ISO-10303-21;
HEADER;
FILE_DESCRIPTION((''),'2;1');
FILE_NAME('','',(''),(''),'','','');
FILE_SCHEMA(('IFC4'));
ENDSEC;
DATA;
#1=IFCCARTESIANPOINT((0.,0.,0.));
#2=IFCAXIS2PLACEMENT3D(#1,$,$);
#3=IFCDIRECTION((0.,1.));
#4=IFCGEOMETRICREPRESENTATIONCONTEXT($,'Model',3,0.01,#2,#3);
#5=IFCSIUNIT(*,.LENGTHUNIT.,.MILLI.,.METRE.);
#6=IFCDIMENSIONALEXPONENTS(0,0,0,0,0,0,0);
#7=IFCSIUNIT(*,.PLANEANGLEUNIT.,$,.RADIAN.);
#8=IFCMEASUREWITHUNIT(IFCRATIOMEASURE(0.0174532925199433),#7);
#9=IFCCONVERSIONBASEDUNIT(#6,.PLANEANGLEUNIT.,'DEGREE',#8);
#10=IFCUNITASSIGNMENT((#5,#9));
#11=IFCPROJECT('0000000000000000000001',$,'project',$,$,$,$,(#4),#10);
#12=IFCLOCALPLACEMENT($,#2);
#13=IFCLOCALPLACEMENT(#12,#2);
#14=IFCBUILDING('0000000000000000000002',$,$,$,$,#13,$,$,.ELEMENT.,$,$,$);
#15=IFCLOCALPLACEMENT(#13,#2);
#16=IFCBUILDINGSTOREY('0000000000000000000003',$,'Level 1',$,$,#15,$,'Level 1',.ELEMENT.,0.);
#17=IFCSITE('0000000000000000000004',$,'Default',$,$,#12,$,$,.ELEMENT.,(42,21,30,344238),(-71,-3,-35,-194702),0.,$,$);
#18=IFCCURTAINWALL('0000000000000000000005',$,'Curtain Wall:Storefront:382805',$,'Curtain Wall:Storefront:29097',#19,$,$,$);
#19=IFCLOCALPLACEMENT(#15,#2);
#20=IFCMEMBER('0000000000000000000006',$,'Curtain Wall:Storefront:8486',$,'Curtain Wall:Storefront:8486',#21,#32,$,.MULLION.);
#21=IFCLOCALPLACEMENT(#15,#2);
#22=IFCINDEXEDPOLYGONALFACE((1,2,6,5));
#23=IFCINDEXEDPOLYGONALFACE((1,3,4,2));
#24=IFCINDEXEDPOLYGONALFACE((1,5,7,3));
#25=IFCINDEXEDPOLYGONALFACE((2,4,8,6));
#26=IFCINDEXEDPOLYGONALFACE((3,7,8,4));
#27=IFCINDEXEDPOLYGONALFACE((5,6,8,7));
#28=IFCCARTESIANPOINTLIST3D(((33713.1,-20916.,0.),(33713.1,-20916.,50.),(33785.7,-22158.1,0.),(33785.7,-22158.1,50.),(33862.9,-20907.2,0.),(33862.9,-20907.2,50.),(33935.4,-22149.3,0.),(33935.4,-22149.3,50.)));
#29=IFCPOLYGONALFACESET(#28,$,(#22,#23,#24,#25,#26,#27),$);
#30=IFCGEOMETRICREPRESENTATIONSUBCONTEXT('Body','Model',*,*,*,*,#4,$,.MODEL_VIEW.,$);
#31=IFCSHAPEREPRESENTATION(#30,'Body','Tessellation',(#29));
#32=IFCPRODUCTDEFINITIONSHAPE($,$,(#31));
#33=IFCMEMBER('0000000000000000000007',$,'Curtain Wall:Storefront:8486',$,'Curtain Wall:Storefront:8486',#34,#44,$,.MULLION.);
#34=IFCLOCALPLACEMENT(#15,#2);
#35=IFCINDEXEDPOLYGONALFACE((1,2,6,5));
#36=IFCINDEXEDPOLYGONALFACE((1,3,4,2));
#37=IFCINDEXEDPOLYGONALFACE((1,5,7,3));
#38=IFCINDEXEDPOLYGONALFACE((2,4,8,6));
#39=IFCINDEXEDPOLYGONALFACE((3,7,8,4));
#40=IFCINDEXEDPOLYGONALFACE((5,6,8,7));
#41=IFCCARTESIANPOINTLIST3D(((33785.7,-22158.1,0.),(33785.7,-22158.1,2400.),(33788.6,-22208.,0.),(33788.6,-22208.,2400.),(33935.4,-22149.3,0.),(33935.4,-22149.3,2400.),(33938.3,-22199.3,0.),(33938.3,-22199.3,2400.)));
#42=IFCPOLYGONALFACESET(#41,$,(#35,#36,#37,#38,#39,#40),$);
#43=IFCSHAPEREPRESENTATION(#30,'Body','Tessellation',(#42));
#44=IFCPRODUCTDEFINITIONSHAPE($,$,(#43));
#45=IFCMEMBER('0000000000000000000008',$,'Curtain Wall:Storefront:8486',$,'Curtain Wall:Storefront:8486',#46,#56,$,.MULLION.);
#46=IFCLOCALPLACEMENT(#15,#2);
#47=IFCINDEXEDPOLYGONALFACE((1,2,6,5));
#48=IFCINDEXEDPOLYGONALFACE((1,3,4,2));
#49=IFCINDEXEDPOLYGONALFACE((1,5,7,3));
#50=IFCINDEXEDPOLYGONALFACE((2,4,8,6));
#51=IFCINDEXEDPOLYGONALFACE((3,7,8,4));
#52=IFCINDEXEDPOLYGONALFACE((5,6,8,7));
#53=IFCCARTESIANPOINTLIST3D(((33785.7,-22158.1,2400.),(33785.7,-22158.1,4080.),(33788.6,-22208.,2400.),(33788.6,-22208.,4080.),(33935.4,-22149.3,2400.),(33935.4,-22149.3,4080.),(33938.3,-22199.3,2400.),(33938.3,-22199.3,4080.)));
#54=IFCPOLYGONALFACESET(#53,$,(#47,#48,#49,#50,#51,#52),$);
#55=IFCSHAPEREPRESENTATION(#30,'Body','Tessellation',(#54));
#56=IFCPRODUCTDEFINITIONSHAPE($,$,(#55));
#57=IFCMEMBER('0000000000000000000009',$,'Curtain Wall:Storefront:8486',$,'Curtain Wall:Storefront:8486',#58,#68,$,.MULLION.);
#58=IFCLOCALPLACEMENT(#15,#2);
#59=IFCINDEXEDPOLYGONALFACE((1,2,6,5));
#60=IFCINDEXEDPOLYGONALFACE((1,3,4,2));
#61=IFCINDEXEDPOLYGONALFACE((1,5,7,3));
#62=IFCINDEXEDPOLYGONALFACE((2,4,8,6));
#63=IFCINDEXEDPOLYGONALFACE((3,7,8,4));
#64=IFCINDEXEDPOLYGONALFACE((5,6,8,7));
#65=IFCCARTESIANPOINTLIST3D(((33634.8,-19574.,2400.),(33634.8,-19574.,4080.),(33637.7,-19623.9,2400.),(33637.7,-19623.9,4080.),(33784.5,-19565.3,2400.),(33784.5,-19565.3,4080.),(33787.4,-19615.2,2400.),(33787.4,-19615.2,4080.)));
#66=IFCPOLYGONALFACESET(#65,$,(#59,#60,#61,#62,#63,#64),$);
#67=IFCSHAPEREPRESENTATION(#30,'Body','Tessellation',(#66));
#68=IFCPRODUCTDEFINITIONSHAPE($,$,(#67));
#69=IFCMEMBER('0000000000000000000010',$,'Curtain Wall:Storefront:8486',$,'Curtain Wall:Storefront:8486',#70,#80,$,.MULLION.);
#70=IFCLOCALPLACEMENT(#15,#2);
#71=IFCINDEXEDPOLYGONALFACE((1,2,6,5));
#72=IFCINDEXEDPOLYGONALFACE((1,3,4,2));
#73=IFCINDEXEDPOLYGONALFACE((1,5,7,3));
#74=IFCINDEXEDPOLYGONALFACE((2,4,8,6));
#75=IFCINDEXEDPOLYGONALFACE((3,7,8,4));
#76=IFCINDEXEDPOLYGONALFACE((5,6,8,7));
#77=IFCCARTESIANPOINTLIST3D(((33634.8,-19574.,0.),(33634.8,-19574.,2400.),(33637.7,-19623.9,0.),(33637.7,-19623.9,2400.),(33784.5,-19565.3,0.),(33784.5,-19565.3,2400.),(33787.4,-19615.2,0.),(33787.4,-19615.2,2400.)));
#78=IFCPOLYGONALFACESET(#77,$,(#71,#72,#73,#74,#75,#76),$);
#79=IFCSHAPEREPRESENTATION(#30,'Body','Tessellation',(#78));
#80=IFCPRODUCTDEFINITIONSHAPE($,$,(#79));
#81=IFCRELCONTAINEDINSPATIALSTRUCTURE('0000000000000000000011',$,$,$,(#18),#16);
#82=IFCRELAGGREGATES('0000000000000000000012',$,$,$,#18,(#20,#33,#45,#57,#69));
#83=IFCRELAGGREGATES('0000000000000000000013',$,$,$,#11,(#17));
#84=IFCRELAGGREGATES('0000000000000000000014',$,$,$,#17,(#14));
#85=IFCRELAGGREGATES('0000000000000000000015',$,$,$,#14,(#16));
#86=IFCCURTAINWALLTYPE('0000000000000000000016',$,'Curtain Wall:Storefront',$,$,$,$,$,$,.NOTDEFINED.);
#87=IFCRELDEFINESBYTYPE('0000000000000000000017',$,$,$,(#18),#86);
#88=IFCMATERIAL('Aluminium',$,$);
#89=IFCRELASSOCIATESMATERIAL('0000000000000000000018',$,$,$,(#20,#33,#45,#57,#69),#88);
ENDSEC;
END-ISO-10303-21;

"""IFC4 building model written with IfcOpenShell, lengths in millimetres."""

from ifc_helpers import new_model, entity, si_unit, converted_unit, direction, frame, origin, origin_2d_with_axis, place, context, subcontext, project, spatial, rectangle, extrude, material, type_object, element, aggregate, save


model = new_model("IFC4")

# Units and contexts
model_context = context("Model", 3, precision=0.01, world=origin(), true_north=direction((0.0, 1.0)))
body_context = subcontext(model_context, "Body", "Model", "MODEL_VIEW")
ifc_project = project(units=[si_unit("LENGTHUNIT", "METRE", prefix="MILLI"), converted_unit("PLANEANGLEUNIT", "DEGREE", entity("IfcRatioMeasure", 0.0174532925199433), si_unit("PLANEANGLEUNIT", "RADIAN"), dimensions=[0, 0, 0, 0, 0, 0, 0])], contexts=[model_context])

# Site, building, storey
site_placement = place(None, origin())
site = spatial("IfcSite", under=ifc_project, at=site_placement, Name="Default", CompositionType="ELEMENT", RefLatitude=(42, 21, 30, 344238), RefLongitude=(-71, -3, -35, -194702), RefElevation=0.0)
building_placement = place(site_placement, origin())
building = spatial("IfcBuilding", under=site, at=building_placement, CompositionType="ELEMENT")
storey_placement = place(building_placement, origin())
storey = spatial("IfcBuildingStorey", under=building, at=storey_placement, Name="Level 1", LongName="Level 1", CompositionType="ELEMENT", Elevation=0.0)

# Curtain wall, members
curtain_wall_type = type_object("IfcCurtainWallType", Name="Curtain Wall:Storefront", PredefinedType="NOTDEFINED")
ifc_material = material(Name="Aluminium")
curtain_wall_1_placement = place(storey_placement, origin())
curtain_wall_1 = element("IfcCurtainWall", 1, at=curtain_wall_1_placement, inside=storey, type_object=curtain_wall_type, Name="Curtain Wall:Storefront:382805", ObjectType="Curtain Wall:Storefront:29097")
member_1_placement = place(curtain_wall_1_placement, origin())
member_1 = element("IfcMember", 2, at=member_1_placement, material=ifc_material, Name="Curtain Wall:Storefront:8486", ObjectType="Curtain Wall:Storefront:8486", PredefinedType="MULLION", context=body_context, shape_type="SweptSolid", body=[
    extrude(rectangle(XDim=50.0, YDim=150.0, at=origin_2d_with_axis()), frame((33788.0, -20911.6, 25.0), z_axis=(0.058298, -0.998299, 0.0), x_axis=(0.0, 0.0, -1.0)), (0.0, 0.0, 1.0), 1244.2),
])
member_2_placement = place(curtain_wall_1_placement, origin())
member_2 = element("IfcMember", 3, at=member_2_placement, material=ifc_material, Name="Curtain Wall:Storefront:8486", ObjectType="Curtain Wall:Storefront:8486", PredefinedType="MULLION", context=body_context, shape_type="SweptSolid", body=[
    extrude(rectangle(XDim=150.0, YDim=50.0, at=origin_2d_with_axis()), frame((33862.0, -22178.7, 0.0), z_axis=(0.0, 0.0, 1.0), x_axis=(0.998299, 0.058298, 0.0)), (0.0, 0.0, 1.0), 2400.0),
])
member_3_placement = place(curtain_wall_1_placement, origin())
member_3 = element("IfcMember", 4, at=member_3_placement, material=ifc_material, Name="Curtain Wall:Storefront:8486", ObjectType="Curtain Wall:Storefront:8486", PredefinedType="MULLION", context=body_context, shape_type="SweptSolid", body=[
    extrude(rectangle(XDim=150.0, YDim=50.0, at=origin_2d_with_axis()), frame((33862.0, -22178.7, 2400.0), z_axis=(0.0, 0.0, 1.0), x_axis=(0.998299, 0.058298, 0.0)), (0.0, 0.0, 1.0), 1680.0),
])
member_4_placement = place(curtain_wall_1_placement, origin())
member_4 = element("IfcMember", 5, at=member_4_placement, material=ifc_material, Name="Curtain Wall:Storefront:8486", ObjectType="Curtain Wall:Storefront:8486", PredefinedType="MULLION", context=body_context, shape_type="SweptSolid", body=[
    extrude(rectangle(XDim=150.0, YDim=50.0, at=origin_2d_with_axis()), frame((33711.1, -19594.6, 4080.0), z_axis=(0.0, 0.0, -1.0), x_axis=(0.998299, 0.058298, 0.0)), (0.0, 0.0, 1.0), 1680.0),
])
member_5_placement = place(curtain_wall_1_placement, origin())
member_5 = element("IfcMember", 6, at=member_5_placement, material=ifc_material, Name="Curtain Wall:Storefront:8486", ObjectType="Curtain Wall:Storefront:8486", PredefinedType="MULLION", context=body_context, shape_type="SweptSolid", body=[
    extrude(rectangle(XDim=150.0, YDim=50.0, at=origin_2d_with_axis()), frame((33711.1, -19594.6, 2400.0), z_axis=(0.0, 0.0, -1.0), x_axis=(0.998299, 0.058298, 0.0)), (0.0, 0.0, 1.0), 2400.0),
])
aggregate(curtain_wall_1, [member_1, member_2, member_3, member_4, member_5])

save(model, "model.ifc")
